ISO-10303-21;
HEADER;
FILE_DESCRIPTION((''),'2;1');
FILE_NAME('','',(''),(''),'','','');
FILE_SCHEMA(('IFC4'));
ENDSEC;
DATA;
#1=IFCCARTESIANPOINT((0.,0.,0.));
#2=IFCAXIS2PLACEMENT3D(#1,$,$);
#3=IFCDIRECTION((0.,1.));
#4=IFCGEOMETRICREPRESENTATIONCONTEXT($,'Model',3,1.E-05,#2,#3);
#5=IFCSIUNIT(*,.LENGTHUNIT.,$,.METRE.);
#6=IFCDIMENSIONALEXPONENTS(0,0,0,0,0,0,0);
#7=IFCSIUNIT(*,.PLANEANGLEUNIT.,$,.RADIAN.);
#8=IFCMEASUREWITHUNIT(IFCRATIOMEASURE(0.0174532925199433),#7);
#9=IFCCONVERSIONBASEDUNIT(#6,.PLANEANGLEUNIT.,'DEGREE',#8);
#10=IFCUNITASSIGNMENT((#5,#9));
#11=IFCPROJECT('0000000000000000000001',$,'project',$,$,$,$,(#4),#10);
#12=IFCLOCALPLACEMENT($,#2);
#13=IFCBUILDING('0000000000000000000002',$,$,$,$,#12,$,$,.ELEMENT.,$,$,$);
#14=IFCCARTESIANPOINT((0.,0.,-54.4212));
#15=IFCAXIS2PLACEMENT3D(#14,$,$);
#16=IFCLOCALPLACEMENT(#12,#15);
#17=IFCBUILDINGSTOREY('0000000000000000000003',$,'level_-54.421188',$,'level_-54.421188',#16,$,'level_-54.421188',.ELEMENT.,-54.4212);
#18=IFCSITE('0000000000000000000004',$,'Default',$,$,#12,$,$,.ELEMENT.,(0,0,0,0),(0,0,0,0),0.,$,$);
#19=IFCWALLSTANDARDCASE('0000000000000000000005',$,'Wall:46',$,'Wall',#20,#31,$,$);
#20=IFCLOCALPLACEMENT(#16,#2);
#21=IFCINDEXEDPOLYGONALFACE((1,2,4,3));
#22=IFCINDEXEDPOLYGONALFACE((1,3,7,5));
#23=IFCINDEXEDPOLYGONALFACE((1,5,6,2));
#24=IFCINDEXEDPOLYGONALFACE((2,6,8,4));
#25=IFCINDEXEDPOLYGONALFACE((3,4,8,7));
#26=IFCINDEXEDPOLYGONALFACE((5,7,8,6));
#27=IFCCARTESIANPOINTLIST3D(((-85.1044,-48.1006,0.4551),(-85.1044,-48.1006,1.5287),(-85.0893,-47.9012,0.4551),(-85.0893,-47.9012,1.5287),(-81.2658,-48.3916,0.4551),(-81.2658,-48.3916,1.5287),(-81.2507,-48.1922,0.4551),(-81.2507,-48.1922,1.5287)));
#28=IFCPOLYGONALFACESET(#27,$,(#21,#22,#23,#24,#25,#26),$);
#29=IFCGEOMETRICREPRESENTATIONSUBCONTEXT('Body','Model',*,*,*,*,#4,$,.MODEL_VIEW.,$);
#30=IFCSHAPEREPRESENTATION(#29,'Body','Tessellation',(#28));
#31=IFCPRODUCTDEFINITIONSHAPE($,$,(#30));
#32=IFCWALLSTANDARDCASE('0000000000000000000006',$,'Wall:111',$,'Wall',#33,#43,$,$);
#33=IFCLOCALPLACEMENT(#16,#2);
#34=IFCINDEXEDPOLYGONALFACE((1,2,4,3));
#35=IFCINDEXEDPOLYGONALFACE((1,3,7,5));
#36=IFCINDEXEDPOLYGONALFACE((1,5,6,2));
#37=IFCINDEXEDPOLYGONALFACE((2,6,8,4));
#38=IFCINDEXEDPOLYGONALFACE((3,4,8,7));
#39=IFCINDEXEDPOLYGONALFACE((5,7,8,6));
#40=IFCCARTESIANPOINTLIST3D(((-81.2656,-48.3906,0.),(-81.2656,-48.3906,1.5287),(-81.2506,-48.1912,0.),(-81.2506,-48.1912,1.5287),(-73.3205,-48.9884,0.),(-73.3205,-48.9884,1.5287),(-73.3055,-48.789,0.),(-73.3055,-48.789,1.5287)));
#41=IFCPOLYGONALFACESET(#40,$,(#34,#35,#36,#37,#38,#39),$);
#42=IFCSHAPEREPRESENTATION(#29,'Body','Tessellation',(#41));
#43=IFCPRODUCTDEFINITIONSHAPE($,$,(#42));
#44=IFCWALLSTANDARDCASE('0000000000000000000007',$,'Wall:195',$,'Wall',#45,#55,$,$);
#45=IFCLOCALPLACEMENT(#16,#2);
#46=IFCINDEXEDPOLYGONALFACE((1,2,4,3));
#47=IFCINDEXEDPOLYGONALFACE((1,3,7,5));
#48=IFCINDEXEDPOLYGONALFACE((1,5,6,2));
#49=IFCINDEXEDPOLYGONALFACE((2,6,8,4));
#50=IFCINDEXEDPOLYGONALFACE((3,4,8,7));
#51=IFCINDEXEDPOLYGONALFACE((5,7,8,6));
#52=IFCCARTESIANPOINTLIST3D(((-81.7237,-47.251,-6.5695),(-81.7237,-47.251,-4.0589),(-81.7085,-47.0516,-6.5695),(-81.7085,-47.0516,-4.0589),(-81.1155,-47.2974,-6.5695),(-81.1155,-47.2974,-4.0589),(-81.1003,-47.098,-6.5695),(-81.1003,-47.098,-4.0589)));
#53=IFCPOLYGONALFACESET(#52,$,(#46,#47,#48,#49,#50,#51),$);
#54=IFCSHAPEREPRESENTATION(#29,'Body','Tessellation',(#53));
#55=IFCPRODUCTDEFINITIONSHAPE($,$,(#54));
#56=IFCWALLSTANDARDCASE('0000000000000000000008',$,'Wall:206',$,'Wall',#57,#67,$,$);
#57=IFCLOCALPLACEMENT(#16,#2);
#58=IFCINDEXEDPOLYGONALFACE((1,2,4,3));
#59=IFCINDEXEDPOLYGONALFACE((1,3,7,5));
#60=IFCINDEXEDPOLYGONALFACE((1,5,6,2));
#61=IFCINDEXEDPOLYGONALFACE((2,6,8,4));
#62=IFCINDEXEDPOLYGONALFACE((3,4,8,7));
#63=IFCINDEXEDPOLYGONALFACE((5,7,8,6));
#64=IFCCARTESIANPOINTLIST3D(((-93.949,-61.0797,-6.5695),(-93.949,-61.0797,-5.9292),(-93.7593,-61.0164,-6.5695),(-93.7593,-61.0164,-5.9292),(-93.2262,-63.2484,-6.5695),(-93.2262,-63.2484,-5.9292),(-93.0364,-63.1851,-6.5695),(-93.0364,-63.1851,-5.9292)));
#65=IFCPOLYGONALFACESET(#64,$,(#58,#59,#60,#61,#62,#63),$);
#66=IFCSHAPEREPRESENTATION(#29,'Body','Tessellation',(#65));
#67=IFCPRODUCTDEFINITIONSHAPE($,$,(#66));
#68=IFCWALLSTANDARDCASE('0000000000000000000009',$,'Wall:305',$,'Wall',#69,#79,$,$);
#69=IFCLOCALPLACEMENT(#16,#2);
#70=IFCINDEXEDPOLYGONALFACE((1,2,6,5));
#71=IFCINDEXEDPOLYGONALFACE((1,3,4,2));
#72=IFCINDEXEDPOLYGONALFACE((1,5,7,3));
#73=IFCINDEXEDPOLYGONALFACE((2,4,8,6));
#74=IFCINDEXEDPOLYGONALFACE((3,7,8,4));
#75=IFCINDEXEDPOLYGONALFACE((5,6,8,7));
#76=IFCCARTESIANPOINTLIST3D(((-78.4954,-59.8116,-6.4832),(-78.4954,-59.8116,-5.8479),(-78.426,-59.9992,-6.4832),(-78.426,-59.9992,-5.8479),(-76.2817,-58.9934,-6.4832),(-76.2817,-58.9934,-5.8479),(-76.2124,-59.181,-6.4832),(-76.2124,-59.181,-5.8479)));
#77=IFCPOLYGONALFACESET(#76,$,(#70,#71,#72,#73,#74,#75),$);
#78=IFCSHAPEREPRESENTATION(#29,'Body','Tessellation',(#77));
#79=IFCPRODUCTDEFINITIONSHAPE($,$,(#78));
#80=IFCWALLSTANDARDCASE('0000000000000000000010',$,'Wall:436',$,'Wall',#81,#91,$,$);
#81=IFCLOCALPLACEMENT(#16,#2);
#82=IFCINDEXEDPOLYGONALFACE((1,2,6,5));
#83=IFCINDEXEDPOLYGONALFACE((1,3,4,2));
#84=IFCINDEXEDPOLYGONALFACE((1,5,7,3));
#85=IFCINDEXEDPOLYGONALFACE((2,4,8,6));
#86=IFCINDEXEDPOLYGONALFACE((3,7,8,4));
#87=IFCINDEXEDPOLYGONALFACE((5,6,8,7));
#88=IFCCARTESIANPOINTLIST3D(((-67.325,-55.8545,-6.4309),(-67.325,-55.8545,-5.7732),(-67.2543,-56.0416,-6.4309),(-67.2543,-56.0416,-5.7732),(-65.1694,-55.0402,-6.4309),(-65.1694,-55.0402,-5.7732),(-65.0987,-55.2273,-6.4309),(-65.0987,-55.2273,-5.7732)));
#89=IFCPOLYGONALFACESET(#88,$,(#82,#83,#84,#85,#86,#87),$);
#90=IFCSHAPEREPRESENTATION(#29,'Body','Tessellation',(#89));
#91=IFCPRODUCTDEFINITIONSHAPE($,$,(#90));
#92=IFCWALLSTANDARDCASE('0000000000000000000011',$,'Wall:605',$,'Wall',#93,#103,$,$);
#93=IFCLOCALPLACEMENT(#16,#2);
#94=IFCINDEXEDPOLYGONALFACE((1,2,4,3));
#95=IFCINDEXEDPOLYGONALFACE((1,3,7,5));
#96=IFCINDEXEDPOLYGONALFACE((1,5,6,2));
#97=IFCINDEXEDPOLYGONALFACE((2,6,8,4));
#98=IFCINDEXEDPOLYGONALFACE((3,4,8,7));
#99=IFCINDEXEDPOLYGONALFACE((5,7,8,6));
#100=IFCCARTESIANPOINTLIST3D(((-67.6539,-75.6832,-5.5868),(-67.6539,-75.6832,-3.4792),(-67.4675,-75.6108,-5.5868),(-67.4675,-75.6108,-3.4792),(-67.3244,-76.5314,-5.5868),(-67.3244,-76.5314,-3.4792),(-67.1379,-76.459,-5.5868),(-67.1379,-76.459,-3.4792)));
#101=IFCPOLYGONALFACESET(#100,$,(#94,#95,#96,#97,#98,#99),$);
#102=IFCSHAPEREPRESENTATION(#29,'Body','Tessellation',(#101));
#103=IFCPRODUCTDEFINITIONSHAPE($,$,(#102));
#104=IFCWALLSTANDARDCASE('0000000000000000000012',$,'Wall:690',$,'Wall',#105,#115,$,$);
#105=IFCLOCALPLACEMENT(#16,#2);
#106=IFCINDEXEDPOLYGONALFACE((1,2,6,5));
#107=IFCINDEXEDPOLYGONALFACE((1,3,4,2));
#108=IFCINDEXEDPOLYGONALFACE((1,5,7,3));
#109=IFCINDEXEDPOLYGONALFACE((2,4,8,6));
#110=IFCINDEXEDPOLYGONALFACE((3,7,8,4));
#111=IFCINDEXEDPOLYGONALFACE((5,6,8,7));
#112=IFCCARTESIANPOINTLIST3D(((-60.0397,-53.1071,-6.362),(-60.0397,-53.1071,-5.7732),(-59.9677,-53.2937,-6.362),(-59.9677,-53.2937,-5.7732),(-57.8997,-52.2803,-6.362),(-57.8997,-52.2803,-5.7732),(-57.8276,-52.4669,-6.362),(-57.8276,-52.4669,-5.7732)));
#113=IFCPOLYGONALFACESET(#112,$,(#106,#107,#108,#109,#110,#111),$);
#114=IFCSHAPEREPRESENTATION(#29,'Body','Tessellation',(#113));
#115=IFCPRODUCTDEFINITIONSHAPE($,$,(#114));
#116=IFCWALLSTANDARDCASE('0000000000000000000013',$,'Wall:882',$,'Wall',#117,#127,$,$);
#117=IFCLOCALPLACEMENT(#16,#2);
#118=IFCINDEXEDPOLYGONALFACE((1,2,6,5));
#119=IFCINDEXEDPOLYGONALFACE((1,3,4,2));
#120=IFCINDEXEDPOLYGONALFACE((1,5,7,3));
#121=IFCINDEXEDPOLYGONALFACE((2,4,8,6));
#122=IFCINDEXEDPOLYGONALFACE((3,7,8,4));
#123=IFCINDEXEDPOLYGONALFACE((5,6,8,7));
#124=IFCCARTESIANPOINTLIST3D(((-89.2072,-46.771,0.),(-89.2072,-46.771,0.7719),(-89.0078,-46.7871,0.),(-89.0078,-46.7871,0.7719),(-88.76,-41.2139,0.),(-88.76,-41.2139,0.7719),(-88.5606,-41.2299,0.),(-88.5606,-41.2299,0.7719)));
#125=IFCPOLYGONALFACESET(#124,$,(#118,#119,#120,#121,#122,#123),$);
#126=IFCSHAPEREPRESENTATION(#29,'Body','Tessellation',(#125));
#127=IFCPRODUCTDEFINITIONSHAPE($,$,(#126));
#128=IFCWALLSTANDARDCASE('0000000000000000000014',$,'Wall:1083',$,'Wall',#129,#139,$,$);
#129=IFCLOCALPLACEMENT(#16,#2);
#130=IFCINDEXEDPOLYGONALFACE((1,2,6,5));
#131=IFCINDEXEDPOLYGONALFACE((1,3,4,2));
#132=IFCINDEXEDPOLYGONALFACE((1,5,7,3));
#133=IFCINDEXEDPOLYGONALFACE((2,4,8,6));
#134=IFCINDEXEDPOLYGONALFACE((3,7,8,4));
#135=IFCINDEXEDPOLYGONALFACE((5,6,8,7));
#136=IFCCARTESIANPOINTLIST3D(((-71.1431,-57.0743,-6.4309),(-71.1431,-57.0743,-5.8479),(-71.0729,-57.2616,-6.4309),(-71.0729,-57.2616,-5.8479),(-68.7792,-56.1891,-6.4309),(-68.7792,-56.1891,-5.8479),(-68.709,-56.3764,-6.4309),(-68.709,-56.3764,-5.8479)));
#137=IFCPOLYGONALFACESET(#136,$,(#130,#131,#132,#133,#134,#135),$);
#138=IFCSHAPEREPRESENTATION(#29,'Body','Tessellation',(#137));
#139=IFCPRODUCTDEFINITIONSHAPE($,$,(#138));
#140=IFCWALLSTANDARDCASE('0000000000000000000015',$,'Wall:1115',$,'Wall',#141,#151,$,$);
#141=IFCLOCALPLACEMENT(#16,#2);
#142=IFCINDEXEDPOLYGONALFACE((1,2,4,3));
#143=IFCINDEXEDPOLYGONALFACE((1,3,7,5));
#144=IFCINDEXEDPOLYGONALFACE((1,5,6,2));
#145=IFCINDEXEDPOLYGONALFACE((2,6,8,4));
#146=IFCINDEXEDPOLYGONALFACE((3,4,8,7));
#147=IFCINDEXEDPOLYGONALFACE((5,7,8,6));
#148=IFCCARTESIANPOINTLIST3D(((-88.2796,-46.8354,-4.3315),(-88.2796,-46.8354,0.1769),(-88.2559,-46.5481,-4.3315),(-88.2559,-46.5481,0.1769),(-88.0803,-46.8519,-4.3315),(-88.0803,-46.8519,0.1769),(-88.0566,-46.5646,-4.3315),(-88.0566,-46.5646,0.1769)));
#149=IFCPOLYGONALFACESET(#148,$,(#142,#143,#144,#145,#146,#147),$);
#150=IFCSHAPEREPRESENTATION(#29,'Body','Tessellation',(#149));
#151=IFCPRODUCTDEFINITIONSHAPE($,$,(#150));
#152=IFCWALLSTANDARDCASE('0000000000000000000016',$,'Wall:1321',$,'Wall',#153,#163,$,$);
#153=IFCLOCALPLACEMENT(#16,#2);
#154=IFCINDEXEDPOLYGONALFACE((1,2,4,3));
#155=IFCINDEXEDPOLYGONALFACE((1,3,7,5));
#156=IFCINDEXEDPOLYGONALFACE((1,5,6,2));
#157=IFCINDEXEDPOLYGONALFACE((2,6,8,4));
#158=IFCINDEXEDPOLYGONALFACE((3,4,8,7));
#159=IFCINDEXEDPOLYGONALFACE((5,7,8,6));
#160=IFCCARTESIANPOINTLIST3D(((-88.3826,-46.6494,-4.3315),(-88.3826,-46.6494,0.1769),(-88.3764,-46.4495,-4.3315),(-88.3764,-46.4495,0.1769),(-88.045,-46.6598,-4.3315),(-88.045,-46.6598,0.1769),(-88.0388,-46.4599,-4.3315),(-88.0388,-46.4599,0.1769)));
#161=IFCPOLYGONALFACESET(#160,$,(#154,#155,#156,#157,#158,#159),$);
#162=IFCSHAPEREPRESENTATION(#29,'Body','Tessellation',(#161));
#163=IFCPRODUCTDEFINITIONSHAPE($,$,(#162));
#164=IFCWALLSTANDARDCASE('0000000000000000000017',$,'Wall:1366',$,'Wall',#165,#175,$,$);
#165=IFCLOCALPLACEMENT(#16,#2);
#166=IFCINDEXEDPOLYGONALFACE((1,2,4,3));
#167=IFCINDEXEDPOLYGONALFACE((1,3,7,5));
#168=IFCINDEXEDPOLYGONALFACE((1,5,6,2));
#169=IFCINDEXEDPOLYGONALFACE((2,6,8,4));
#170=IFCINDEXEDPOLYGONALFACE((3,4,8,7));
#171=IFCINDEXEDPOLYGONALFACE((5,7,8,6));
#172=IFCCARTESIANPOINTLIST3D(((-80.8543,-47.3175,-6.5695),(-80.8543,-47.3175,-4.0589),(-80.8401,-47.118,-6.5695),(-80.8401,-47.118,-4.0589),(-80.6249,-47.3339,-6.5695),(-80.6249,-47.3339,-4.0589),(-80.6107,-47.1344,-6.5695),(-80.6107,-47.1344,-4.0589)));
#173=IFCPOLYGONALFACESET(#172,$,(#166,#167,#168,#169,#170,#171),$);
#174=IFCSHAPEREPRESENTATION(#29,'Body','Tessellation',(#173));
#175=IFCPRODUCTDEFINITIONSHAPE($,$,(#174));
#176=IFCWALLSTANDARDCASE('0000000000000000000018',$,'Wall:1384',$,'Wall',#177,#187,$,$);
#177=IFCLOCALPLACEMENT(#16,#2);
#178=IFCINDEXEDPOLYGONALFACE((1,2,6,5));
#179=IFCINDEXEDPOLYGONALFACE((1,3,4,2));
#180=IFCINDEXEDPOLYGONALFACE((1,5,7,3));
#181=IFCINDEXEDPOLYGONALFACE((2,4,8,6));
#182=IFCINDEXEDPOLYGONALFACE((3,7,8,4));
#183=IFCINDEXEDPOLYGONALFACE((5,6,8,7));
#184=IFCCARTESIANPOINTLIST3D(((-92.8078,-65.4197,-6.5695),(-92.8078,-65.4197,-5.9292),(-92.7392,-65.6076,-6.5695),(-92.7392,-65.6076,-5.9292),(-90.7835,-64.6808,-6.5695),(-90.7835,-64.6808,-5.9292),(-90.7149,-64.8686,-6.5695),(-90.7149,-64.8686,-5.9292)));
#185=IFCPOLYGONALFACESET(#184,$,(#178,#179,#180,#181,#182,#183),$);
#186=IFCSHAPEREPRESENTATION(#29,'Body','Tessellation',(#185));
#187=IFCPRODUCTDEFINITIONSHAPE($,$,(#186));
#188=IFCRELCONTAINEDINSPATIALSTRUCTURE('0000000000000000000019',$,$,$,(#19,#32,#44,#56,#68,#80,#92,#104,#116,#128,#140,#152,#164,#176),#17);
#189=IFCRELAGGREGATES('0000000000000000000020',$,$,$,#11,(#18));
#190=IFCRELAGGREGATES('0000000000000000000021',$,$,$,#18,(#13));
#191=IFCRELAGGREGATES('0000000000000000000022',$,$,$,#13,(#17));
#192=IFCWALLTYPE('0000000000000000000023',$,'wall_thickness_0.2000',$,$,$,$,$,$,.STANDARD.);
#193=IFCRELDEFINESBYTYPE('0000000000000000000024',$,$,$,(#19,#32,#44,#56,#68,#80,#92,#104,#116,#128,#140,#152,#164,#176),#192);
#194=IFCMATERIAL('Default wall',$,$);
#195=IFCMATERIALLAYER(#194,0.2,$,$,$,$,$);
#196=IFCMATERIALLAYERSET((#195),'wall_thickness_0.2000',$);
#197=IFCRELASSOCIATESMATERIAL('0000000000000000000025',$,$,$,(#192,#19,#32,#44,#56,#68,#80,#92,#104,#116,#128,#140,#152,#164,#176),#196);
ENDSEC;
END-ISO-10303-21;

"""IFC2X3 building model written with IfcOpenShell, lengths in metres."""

from ifc_helpers import new_model, entity, si_unit, converted_unit, direction, frame, origin, place, context, subcontext, project, spatial, polyline, outline, extrude, material, layer, layer_set, layer_usage, type_object, element, save


model = new_model("IFC2X3")

# Units and contexts
model_context = context("Model", 3, precision=1e-05, world=origin(), true_north=direction((0.0, 1.0)))
body_context = subcontext(model_context, "Body", "Model", "MODEL_VIEW")
ifc_project = project(units=[si_unit("LENGTHUNIT", "METRE"), converted_unit("PLANEANGLEUNIT", "DEGREE", entity("IfcRatioMeasure", 0.0174532925199433), si_unit("PLANEANGLEUNIT", "RADIAN"), dimensions=[0, 0, 0, 0, 0, 0, 0])], contexts=[model_context])

# Site, building, storey
placement_1 = place(None, origin())
site = spatial("IfcSite", under=ifc_project, at=placement_1, Name="Default", CompositionType="ELEMENT", RefLatitude=(0, 0, 0, 0), RefLongitude=(0, 0, 0, 0), RefElevation=0.0)
building = spatial("IfcBuilding", under=site, at=placement_1, CompositionType="ELEMENT")
storey_placement = place(placement_1, frame((0.0, 0.0, -54.4212)))
storey = spatial("IfcBuildingStorey", under=building, at=storey_placement, Name="level_-54.421188", ObjectType="level_-54.421188", LongName="level_-54.421188", CompositionType="ELEMENT", Elevation=-54.4212)

# Walls
ifc_material = material(Name="Default wall")
ifc_layer = layer(ifc_material, 0.2)
ifc_layer_set = layer_set([ifc_layer], Name="wall_thickness_0.2000")
ifc_layer_usage = layer_usage(ifc_layer_set, "AXIS2", "POSITIVE", -0.1)
wall_type = type_object("IfcWallType", Name="wall_thickness_0.2000", PredefinedType="STANDARD", material=ifc_layer_set)
placement_2 = place(placement_1, frame((0.0, 0.0, -53.9661)))
wall_1_placement = place(placement_2, frame((-85.0968, -48.0009, 0.0), z_axis=(0.0, 0.0, 1.0), x_axis=(0.99714, -0.07558, 0.0)))
element("IfcWallStandardCase", 1, at=wall_1_placement, inside=storey, type_object=wall_type, material=ifc_layer_usage, Name="Wall:46", ObjectType="Wall", context=body_context, shape_type="SweptSolid", body=[
    extrude(outline(polyline([(3.8496, -0.1), (3.8496, 0.1), (0.0, 0.1), (0.0, -0.1), (3.8496, -0.1)])), origin(), (0.0, 0.0, 1.0), 1.0737),
])
wall_2_placement = place(storey_placement, frame((-81.2581, -48.2909, 0.0), z_axis=(0.0, 0.0, 1.0), x_axis=(0.997181, -0.075029, 0.0)))
element("IfcWallStandardCase", 2, at=wall_2_placement, inside=storey, type_object=wall_type, material=ifc_layer_usage, Name="Wall:111", ObjectType="Wall", context=body_context, shape_type="SweptSolid", body=[
    extrude(outline(polyline([(7.9675, -0.1), (7.9675, 0.1), (0.0, 0.1), (0.0, -0.1), (7.9675, -0.1)])), origin(), (0.0, 0.0, 1.0), 1.5287),
])
placement_3 = place(placement_1, frame((0.0, 0.0, -60.9907)))
wall_3_placement = place(placement_3, frame((-81.1079, -47.1977, 0.0), z_axis=(0.0, 0.0, 1.0), x_axis=(-0.997108, 0.076, 0.0)))
element("IfcWallStandardCase", 3, at=wall_3_placement, inside=storey, type_object=wall_type, material=ifc_layer_usage, Name="Wall:195", ObjectType="Wall", context=body_context, shape_type="SweptSolid", body=[
    extrude(outline(polyline([(0.61, -0.1), (0.61, 0.1), (0.0, 0.1), (0.0, -0.1), (0.61, -0.1)])), origin(), (0.0, 0.0, 1.0), 2.5105),
])
placement_4 = place(placement_1, frame((0.0, 0.0, -60.9907)))
wall_4_placement = place(placement_4, frame((-93.8542, -61.0481, 0.0), z_axis=(0.0, 0.0, 1.0), x_axis=(0.316213, -0.948688, 0.0)))
element("IfcWallStandardCase", 4, at=wall_4_placement, inside=storey, type_object=wall_type, material=ifc_layer_usage, Name="Wall:206", ObjectType="Wall", context=body_context, shape_type="SweptSolid", body=[
    extrude(outline(polyline([(2.286, -0.1), (2.286, 0.1), (0.0, 0.1), (0.0, -0.1), (2.286, -0.1)])), origin(), (0.0, 0.0, 1.0), 0.6403),
])
placement_5 = place(placement_1, frame((0.0, 0.0, -60.9044)))
wall_5_placement = place(placement_5, frame((-78.4607, -59.9054, 0.0), z_axis=(0.0, 0.0, 1.0), x_axis=(0.937984, 0.346678, 0.0)))
element("IfcWallStandardCase", 5, at=wall_5_placement, inside=storey, type_object=wall_type, material=ifc_layer_usage, Name="Wall:305", ObjectType="Wall", context=body_context, shape_type="SweptSolid", body=[
    extrude(outline(polyline([(2.36, -0.1), (2.36, 0.1), (0.0, 0.1), (0.0, -0.1), (2.36, -0.1)])), origin(), (0.0, 0.0, 1.0), 0.6353),
])
placement_6 = place(placement_1, frame((0.0, 0.0, -60.8521)))
wall_6_placement = place(placement_6, frame((-67.2897, -55.9481, 0.0), z_axis=(0.0, 0.0, 1.0), x_axis=(0.935474, 0.353395, 0.0)))
element("IfcWallStandardCase", 6, at=wall_6_placement, inside=storey, type_object=wall_type, material=ifc_layer_usage, Name="Wall:436", ObjectType="Wall", context=body_context, shape_type="SweptSolid", body=[
    extrude(outline(polyline([(2.3043, -0.1), (2.3043, 0.1), (0.0, 0.1), (0.0, -0.1), (2.3043, -0.1)])), origin(), (0.0, 0.0, 1.0), 0.6577),
])
placement_7 = place(placement_1, frame((0.0, 0.0, -60.008)))
wall_7_placement = place(placement_7, frame((-67.2312, -76.4952, 0.0), z_axis=(0.0, 0.0, 1.0), x_axis=(-0.36217, 0.932112, 0.0)))
element("IfcWallStandardCase", 7, at=wall_7_placement, inside=storey, type_object=wall_type, material=ifc_layer_usage, Name="Wall:605", ObjectType="Wall", context=body_context, shape_type="SweptSolid", body=[
    extrude(outline(polyline([(0.91, -0.1), (0.91, 0.1), (0.0, 0.1), (0.0, -0.1), (0.91, -0.1)])), origin(), (0.0, 0.0, 1.0), 2.1076),
])
placement_8 = place(placement_1, frame((0.0, 0.0, -60.7832)))
wall_8_placement = place(placement_8, frame((-60.0037, -53.2004, 0.0), z_axis=(0.0, 0.0, 1.0), x_axis=(0.932806, 0.36038, 0.0)))
element("IfcWallStandardCase", 8, at=wall_8_placement, inside=storey, type_object=wall_type, material=ifc_layer_usage, Name="Wall:690", ObjectType="Wall", context=body_context, shape_type="SweptSolid", body=[
    extrude(outline(polyline([(2.2942, -0.1), (2.2942, 0.1), (0.0, 0.1), (0.0, -0.1), (2.2942, -0.1)])), origin(), (0.0, 0.0, 1.0), 0.5888),
])
wall_9_placement = place(storey_placement, frame((-89.1075, -46.779, 0.0), z_axis=(0.0, 0.0, 1.0), x_axis=(0.080215, 0.996778, 0.0)))
element("IfcWallStandardCase", 9, at=wall_9_placement, inside=storey, type_object=wall_type, material=ifc_layer_usage, Name="Wall:882", ObjectType="Wall", context=body_context, shape_type="SweptSolid", body=[
    extrude(outline(polyline([(5.5751, -0.1), (5.5751, 0.1), (0.0, 0.1), (0.0, -0.1), (5.5751, -0.1)])), origin(), (0.0, 0.0, 1.0), 0.7719),
])
placement_9 = place(placement_1, frame((0.0, 0.0, -60.8521)))
wall_10_placement = place(placement_9, frame((-71.108, -57.168, 0.0), z_axis=(0.0, 0.0, 1.0), x_axis=(0.936481, 0.350719, 0.0)))
element("IfcWallStandardCase", 10, at=wall_10_placement, inside=storey, type_object=wall_type, material=ifc_layer_usage, Name="Wall:1083", ObjectType="Wall", context=body_context, shape_type="SweptSolid", body=[
    extrude(outline(polyline([(2.5242, -0.1), (2.5242, 0.1), (0.0, 0.1), (0.0, -0.1), (2.5242, -0.1)])), origin(), (0.0, 0.0, 1.0), 0.5829),
])
placement_10 = place(placement_1, frame((0.0, 0.0, -58.7527)))
wall_11_placement = place(placement_10, frame((-88.18, -46.8436, 0.0), z_axis=(0.0, 0.0, 1.0), x_axis=(0.082336, 0.996605, 0.0)))
element("IfcWallStandardCase", 11, at=wall_11_placement, inside=storey, type_object=wall_type, material=ifc_layer_usage, Name="Wall:1115", ObjectType="Wall", context=body_context, shape_type="SweptSolid", body=[
    extrude(outline(polyline([(0.2883, -0.1), (0.2883, 0.1), (0.0, 0.1), (0.0, -0.1), (0.2883, -0.1)])), origin(), (0.0, 0.0, 1.0), 4.5084),
])
placement_11 = place(placement_1, frame((0.0, 0.0, -58.7527)))
wall_12_placement = place(placement_11, frame((-88.0419, -46.5599, 0.0), z_axis=(0.0, 0.0, 1.0), x_axis=(-0.999523, 0.03089, 0.0)))
element("IfcWallStandardCase", 12, at=wall_12_placement, inside=storey, type_object=wall_type, material=ifc_layer_usage, Name="Wall:1321", ObjectType="Wall", context=body_context, shape_type="SweptSolid", body=[
    extrude(outline(polyline([(0.3378, -0.1), (0.3378, 0.1), (0.0, 0.1), (0.0, -0.1), (0.3378, -0.1)])), origin(), (0.0, 0.0, 1.0), 4.5084),
])
placement_12 = place(placement_1, frame((0.0, 0.0, -60.9907)))
wall_13_placement = place(placement_12, frame((-80.6178, -47.2341, 0.0), z_axis=(0.0, 0.0, 1.0), x_axis=(-0.99748, 0.070952, 0.0)))
element("IfcWallStandardCase", 13, at=wall_13_placement, inside=storey, type_object=wall_type, material=ifc_layer_usage, Name="Wall:1366", ObjectType="Wall", context=body_context, shape_type="SweptSolid", body=[
    extrude(outline(polyline([(0.23, -0.1), (0.23, 0.1), (0.0, 0.1), (0.0, -0.1), (0.23, -0.1)])), origin(), (0.0, 0.0, 1.0), 2.5105),
])
placement_13 = place(placement_1, frame((0.0, 0.0, -60.9907)))
wall_14_placement = place(placement_13, frame((-92.7735, -65.5137, 0.0), z_axis=(0.0, 0.0, 1.0), x_axis=(0.939369, 0.342908, 0.0)))
element("IfcWallStandardCase", 14, at=wall_14_placement, inside=storey, type_object=wall_type, material=ifc_layer_usage, Name="Wall:1384", ObjectType="Wall", context=body_context, shape_type="SweptSolid", body=[
    extrude(outline(polyline([(2.155, -0.1), (2.155, 0.1), (0.0, 0.1), (0.0, -0.1), (2.155, -0.1)])), origin(), (0.0, 0.0, 1.0), 0.6403),
])

save(model, "model.ifc")
